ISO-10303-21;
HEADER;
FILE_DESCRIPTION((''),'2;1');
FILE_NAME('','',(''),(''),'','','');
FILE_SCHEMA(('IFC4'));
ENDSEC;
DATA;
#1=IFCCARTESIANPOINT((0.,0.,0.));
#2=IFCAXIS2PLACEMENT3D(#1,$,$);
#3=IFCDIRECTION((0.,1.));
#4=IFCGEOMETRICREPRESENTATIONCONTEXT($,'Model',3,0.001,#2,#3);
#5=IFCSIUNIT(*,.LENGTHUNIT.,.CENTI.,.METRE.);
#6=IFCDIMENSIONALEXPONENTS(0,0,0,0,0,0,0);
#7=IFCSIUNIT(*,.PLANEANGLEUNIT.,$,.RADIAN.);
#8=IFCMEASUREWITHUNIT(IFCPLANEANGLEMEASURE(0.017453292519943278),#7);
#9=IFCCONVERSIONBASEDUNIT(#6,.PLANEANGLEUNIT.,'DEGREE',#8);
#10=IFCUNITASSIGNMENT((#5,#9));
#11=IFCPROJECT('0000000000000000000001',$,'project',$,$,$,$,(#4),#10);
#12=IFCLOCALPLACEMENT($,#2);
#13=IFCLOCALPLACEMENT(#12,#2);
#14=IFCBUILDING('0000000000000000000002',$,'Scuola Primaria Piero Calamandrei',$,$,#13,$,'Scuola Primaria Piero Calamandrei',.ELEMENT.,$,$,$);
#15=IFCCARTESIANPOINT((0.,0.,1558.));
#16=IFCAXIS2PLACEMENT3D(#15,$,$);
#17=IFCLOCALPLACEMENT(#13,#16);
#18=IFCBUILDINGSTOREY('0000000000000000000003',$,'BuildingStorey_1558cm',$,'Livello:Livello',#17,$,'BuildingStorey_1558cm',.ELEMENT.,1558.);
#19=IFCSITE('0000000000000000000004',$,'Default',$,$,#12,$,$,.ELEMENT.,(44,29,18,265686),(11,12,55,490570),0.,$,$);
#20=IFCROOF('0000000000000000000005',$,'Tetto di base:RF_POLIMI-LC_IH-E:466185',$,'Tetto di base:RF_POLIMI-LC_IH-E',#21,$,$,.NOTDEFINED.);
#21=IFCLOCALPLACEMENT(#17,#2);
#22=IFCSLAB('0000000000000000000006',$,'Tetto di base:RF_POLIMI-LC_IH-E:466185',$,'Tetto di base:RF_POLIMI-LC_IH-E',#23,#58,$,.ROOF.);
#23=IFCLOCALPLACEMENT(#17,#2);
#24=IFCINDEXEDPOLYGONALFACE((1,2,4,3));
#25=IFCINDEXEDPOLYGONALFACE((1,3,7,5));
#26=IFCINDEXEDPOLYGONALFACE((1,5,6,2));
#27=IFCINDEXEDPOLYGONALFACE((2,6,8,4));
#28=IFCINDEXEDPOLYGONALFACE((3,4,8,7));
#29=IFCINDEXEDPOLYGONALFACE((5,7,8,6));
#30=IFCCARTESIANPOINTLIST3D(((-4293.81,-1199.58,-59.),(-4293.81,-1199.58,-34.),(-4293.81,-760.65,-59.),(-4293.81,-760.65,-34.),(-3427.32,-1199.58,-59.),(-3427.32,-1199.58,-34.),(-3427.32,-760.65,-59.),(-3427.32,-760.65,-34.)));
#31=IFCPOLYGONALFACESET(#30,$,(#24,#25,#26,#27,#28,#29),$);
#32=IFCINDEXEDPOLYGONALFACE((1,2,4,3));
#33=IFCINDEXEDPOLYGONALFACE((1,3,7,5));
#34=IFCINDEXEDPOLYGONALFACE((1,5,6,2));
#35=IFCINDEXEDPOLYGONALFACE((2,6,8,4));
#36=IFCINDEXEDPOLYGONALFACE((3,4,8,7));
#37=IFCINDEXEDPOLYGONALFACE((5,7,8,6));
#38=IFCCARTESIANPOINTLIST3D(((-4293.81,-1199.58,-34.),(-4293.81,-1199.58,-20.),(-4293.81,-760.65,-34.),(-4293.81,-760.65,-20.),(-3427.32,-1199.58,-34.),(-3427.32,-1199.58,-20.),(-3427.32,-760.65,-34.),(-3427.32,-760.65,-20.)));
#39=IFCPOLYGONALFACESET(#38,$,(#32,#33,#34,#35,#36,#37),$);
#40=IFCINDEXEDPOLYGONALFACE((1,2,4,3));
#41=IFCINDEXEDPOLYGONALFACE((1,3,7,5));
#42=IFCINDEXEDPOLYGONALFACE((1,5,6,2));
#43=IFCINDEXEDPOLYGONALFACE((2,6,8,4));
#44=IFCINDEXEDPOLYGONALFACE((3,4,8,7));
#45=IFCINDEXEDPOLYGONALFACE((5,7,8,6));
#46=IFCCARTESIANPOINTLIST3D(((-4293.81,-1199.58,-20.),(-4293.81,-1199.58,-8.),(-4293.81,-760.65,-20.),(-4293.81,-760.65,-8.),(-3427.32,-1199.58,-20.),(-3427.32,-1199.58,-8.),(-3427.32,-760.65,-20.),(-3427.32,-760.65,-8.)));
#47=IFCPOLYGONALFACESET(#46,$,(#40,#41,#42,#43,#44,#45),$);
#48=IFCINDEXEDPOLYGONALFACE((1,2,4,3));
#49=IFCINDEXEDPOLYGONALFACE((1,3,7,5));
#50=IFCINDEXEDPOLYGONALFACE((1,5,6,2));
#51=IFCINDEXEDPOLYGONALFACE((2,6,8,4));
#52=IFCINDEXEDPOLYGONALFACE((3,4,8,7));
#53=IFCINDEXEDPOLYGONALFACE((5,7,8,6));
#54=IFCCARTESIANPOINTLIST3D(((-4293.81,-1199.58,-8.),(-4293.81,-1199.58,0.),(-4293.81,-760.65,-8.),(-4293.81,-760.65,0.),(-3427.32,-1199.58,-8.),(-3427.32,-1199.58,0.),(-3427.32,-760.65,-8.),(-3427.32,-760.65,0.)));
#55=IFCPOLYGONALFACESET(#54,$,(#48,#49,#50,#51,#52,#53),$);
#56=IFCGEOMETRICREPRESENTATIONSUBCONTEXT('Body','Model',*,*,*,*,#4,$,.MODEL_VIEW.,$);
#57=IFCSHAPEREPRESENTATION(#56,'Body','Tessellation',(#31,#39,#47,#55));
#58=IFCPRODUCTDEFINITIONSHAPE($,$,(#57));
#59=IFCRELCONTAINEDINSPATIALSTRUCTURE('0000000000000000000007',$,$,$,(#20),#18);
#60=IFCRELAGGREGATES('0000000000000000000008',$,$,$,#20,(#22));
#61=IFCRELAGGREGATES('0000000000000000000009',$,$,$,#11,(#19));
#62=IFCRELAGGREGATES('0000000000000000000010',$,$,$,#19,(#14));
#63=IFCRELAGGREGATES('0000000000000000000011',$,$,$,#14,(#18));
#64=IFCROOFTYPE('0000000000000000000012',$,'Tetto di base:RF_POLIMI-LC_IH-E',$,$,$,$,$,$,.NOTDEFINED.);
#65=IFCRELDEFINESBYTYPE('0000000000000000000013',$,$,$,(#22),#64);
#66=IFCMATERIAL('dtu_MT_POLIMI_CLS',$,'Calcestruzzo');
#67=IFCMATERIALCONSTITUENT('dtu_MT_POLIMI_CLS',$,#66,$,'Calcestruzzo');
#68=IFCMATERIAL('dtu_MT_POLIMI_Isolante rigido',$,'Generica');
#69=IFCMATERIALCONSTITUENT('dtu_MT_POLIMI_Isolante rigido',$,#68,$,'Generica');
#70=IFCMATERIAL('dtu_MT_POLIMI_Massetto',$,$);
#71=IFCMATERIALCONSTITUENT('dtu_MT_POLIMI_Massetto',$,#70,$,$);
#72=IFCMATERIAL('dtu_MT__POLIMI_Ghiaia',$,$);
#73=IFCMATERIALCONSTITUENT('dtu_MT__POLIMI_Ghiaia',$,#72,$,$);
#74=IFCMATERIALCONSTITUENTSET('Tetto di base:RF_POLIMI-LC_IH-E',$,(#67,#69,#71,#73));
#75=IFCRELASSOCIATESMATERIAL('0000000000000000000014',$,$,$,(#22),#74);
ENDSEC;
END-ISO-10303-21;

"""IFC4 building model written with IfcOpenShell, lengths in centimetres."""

from ifc_helpers import new_model, entity, si_unit, converted_unit, direction, frame, origin, place, context, subcontext, project, spatial, indexed_curve, outline, extrude, material, constituent, constituent_set, type_object, element, aggregate, save


model = new_model("IFC4")

# Units and contexts
model_context = context("Model", 3, precision=0.001, world=origin(), true_north=direction((0.0, 1.0)))
body_context = subcontext(model_context, "Body", "Model", "MODEL_VIEW")
ifc_project = project(units=[si_unit("LENGTHUNIT", "METRE", prefix="CENTI"), converted_unit("PLANEANGLEUNIT", "DEGREE", entity("IfcPlaneAngleMeasure", 0.017453292519943278), si_unit("PLANEANGLEUNIT", "RADIAN"), dimensions=[0, 0, 0, 0, 0, 0, 0])], contexts=[model_context])

# Site, building, storey
site_placement = place(None, origin())
site = spatial("IfcSite", under=ifc_project, at=site_placement, Name="Default", CompositionType="ELEMENT", RefLatitude=(44, 29, 18, 265686), RefLongitude=(11, 12, 55, 490570), RefElevation=0.0)
building_placement = place(site_placement, origin())
building = spatial("IfcBuilding", under=site, at=building_placement, Name="Scuola Primaria Piero Calamandrei", LongName="Scuola Primaria Piero Calamandrei", CompositionType="ELEMENT")
storey_placement = place(building_placement, frame((0.0, 0.0, 1558.0)))
storey = spatial("IfcBuildingStorey", under=building, at=storey_placement, Name="BuildingStorey_1558cm", ObjectType="Livello:Livello", LongName="BuildingStorey_1558cm", CompositionType="ELEMENT", Elevation=1558.0)

# Roof, slab
roof_placement = place(storey_placement, frame((-4293.81, -1199.58, -59.0)))
roof = element("IfcRoof", 1, at=roof_placement, inside=storey, Name="Tetto di base:RF_POLIMI-LC_IH-E:466185", ObjectType="Tetto di base:RF_POLIMI-LC_IH-E", PredefinedType="NOTDEFINED")
ifc_material_1 = material(Name="dtu_MT_POLIMI_CLS", Category="Calcestruzzo")
ifc_constituent_1 = constituent(ifc_material_1, Name="dtu_MT_POLIMI_CLS", Category="Calcestruzzo")
ifc_material_2 = material(Name="dtu_MT_POLIMI_Isolante rigido", Category="Generica")
ifc_constituent_2 = constituent(ifc_material_2, Name="dtu_MT_POLIMI_Isolante rigido", Category="Generica")
ifc_material_3 = material(Name="dtu_MT_POLIMI_Massetto")
ifc_constituent_3 = constituent(ifc_material_3, Name="dtu_MT_POLIMI_Massetto")
ifc_material_4 = material(Name="dtu_MT__POLIMI_Ghiaia")
ifc_constituent_4 = constituent(ifc_material_4, Name="dtu_MT__POLIMI_Ghiaia")
ifc_constituent_set = constituent_set(constituents=[ifc_constituent_1, ifc_constituent_2, ifc_constituent_3, ifc_constituent_4], Name="Tetto di base:RF_POLIMI-LC_IH-E")
roof_type = type_object("IfcRoofType", Name="Tetto di base:RF_POLIMI-LC_IH-E", PredefinedType="NOTDEFINED")
slab_placement = place(roof_placement, origin())
slab = element("IfcSlab", 2, at=slab_placement, type_object=roof_type, material=ifc_constituent_set, Name="Tetto di base:RF_POLIMI-LC_IH-E:466185", ObjectType="Tetto di base:RF_POLIMI-LC_IH-E", PredefinedType="ROOF", context=body_context, shape_type="SweptSolid", body=[
    extrude(outline(indexed_curve([(-433.24, -219.46), (433.24, -219.46), (433.24, 219.46), (-433.24, 219.46), (-433.24, -219.46)], self_intersect=False)), frame((433.24, 219.46, 0.0)), (0.0, 0.0, 1.0), 25.0),
    extrude(outline(indexed_curve([(-433.24, -219.46), (433.24, -219.46), (433.24, 219.46), (-433.24, 219.46), (-433.24, -219.46)], self_intersect=False)), frame((433.24, 219.46, 25.0)), (0.0, 0.0, 1.0), 14.0),
    extrude(outline(indexed_curve([(-433.24, -219.46), (433.24, -219.46), (433.24, 219.46), (-433.24, 219.46), (-433.24, -219.46)], self_intersect=False)), frame((433.24, 219.46, 39.0)), (0.0, 0.0, 1.0), 12.0),
    extrude(outline(indexed_curve([(-433.24, -219.46), (433.24, -219.46), (433.24, 219.46), (-433.24, 219.46), (-433.24, -219.46)], self_intersect=False)), frame((433.24, 219.46, 51.0)), (0.0, 0.0, 1.0), 8.0),
])
aggregate(roof, [slab])

save(model, "model.ifc")
